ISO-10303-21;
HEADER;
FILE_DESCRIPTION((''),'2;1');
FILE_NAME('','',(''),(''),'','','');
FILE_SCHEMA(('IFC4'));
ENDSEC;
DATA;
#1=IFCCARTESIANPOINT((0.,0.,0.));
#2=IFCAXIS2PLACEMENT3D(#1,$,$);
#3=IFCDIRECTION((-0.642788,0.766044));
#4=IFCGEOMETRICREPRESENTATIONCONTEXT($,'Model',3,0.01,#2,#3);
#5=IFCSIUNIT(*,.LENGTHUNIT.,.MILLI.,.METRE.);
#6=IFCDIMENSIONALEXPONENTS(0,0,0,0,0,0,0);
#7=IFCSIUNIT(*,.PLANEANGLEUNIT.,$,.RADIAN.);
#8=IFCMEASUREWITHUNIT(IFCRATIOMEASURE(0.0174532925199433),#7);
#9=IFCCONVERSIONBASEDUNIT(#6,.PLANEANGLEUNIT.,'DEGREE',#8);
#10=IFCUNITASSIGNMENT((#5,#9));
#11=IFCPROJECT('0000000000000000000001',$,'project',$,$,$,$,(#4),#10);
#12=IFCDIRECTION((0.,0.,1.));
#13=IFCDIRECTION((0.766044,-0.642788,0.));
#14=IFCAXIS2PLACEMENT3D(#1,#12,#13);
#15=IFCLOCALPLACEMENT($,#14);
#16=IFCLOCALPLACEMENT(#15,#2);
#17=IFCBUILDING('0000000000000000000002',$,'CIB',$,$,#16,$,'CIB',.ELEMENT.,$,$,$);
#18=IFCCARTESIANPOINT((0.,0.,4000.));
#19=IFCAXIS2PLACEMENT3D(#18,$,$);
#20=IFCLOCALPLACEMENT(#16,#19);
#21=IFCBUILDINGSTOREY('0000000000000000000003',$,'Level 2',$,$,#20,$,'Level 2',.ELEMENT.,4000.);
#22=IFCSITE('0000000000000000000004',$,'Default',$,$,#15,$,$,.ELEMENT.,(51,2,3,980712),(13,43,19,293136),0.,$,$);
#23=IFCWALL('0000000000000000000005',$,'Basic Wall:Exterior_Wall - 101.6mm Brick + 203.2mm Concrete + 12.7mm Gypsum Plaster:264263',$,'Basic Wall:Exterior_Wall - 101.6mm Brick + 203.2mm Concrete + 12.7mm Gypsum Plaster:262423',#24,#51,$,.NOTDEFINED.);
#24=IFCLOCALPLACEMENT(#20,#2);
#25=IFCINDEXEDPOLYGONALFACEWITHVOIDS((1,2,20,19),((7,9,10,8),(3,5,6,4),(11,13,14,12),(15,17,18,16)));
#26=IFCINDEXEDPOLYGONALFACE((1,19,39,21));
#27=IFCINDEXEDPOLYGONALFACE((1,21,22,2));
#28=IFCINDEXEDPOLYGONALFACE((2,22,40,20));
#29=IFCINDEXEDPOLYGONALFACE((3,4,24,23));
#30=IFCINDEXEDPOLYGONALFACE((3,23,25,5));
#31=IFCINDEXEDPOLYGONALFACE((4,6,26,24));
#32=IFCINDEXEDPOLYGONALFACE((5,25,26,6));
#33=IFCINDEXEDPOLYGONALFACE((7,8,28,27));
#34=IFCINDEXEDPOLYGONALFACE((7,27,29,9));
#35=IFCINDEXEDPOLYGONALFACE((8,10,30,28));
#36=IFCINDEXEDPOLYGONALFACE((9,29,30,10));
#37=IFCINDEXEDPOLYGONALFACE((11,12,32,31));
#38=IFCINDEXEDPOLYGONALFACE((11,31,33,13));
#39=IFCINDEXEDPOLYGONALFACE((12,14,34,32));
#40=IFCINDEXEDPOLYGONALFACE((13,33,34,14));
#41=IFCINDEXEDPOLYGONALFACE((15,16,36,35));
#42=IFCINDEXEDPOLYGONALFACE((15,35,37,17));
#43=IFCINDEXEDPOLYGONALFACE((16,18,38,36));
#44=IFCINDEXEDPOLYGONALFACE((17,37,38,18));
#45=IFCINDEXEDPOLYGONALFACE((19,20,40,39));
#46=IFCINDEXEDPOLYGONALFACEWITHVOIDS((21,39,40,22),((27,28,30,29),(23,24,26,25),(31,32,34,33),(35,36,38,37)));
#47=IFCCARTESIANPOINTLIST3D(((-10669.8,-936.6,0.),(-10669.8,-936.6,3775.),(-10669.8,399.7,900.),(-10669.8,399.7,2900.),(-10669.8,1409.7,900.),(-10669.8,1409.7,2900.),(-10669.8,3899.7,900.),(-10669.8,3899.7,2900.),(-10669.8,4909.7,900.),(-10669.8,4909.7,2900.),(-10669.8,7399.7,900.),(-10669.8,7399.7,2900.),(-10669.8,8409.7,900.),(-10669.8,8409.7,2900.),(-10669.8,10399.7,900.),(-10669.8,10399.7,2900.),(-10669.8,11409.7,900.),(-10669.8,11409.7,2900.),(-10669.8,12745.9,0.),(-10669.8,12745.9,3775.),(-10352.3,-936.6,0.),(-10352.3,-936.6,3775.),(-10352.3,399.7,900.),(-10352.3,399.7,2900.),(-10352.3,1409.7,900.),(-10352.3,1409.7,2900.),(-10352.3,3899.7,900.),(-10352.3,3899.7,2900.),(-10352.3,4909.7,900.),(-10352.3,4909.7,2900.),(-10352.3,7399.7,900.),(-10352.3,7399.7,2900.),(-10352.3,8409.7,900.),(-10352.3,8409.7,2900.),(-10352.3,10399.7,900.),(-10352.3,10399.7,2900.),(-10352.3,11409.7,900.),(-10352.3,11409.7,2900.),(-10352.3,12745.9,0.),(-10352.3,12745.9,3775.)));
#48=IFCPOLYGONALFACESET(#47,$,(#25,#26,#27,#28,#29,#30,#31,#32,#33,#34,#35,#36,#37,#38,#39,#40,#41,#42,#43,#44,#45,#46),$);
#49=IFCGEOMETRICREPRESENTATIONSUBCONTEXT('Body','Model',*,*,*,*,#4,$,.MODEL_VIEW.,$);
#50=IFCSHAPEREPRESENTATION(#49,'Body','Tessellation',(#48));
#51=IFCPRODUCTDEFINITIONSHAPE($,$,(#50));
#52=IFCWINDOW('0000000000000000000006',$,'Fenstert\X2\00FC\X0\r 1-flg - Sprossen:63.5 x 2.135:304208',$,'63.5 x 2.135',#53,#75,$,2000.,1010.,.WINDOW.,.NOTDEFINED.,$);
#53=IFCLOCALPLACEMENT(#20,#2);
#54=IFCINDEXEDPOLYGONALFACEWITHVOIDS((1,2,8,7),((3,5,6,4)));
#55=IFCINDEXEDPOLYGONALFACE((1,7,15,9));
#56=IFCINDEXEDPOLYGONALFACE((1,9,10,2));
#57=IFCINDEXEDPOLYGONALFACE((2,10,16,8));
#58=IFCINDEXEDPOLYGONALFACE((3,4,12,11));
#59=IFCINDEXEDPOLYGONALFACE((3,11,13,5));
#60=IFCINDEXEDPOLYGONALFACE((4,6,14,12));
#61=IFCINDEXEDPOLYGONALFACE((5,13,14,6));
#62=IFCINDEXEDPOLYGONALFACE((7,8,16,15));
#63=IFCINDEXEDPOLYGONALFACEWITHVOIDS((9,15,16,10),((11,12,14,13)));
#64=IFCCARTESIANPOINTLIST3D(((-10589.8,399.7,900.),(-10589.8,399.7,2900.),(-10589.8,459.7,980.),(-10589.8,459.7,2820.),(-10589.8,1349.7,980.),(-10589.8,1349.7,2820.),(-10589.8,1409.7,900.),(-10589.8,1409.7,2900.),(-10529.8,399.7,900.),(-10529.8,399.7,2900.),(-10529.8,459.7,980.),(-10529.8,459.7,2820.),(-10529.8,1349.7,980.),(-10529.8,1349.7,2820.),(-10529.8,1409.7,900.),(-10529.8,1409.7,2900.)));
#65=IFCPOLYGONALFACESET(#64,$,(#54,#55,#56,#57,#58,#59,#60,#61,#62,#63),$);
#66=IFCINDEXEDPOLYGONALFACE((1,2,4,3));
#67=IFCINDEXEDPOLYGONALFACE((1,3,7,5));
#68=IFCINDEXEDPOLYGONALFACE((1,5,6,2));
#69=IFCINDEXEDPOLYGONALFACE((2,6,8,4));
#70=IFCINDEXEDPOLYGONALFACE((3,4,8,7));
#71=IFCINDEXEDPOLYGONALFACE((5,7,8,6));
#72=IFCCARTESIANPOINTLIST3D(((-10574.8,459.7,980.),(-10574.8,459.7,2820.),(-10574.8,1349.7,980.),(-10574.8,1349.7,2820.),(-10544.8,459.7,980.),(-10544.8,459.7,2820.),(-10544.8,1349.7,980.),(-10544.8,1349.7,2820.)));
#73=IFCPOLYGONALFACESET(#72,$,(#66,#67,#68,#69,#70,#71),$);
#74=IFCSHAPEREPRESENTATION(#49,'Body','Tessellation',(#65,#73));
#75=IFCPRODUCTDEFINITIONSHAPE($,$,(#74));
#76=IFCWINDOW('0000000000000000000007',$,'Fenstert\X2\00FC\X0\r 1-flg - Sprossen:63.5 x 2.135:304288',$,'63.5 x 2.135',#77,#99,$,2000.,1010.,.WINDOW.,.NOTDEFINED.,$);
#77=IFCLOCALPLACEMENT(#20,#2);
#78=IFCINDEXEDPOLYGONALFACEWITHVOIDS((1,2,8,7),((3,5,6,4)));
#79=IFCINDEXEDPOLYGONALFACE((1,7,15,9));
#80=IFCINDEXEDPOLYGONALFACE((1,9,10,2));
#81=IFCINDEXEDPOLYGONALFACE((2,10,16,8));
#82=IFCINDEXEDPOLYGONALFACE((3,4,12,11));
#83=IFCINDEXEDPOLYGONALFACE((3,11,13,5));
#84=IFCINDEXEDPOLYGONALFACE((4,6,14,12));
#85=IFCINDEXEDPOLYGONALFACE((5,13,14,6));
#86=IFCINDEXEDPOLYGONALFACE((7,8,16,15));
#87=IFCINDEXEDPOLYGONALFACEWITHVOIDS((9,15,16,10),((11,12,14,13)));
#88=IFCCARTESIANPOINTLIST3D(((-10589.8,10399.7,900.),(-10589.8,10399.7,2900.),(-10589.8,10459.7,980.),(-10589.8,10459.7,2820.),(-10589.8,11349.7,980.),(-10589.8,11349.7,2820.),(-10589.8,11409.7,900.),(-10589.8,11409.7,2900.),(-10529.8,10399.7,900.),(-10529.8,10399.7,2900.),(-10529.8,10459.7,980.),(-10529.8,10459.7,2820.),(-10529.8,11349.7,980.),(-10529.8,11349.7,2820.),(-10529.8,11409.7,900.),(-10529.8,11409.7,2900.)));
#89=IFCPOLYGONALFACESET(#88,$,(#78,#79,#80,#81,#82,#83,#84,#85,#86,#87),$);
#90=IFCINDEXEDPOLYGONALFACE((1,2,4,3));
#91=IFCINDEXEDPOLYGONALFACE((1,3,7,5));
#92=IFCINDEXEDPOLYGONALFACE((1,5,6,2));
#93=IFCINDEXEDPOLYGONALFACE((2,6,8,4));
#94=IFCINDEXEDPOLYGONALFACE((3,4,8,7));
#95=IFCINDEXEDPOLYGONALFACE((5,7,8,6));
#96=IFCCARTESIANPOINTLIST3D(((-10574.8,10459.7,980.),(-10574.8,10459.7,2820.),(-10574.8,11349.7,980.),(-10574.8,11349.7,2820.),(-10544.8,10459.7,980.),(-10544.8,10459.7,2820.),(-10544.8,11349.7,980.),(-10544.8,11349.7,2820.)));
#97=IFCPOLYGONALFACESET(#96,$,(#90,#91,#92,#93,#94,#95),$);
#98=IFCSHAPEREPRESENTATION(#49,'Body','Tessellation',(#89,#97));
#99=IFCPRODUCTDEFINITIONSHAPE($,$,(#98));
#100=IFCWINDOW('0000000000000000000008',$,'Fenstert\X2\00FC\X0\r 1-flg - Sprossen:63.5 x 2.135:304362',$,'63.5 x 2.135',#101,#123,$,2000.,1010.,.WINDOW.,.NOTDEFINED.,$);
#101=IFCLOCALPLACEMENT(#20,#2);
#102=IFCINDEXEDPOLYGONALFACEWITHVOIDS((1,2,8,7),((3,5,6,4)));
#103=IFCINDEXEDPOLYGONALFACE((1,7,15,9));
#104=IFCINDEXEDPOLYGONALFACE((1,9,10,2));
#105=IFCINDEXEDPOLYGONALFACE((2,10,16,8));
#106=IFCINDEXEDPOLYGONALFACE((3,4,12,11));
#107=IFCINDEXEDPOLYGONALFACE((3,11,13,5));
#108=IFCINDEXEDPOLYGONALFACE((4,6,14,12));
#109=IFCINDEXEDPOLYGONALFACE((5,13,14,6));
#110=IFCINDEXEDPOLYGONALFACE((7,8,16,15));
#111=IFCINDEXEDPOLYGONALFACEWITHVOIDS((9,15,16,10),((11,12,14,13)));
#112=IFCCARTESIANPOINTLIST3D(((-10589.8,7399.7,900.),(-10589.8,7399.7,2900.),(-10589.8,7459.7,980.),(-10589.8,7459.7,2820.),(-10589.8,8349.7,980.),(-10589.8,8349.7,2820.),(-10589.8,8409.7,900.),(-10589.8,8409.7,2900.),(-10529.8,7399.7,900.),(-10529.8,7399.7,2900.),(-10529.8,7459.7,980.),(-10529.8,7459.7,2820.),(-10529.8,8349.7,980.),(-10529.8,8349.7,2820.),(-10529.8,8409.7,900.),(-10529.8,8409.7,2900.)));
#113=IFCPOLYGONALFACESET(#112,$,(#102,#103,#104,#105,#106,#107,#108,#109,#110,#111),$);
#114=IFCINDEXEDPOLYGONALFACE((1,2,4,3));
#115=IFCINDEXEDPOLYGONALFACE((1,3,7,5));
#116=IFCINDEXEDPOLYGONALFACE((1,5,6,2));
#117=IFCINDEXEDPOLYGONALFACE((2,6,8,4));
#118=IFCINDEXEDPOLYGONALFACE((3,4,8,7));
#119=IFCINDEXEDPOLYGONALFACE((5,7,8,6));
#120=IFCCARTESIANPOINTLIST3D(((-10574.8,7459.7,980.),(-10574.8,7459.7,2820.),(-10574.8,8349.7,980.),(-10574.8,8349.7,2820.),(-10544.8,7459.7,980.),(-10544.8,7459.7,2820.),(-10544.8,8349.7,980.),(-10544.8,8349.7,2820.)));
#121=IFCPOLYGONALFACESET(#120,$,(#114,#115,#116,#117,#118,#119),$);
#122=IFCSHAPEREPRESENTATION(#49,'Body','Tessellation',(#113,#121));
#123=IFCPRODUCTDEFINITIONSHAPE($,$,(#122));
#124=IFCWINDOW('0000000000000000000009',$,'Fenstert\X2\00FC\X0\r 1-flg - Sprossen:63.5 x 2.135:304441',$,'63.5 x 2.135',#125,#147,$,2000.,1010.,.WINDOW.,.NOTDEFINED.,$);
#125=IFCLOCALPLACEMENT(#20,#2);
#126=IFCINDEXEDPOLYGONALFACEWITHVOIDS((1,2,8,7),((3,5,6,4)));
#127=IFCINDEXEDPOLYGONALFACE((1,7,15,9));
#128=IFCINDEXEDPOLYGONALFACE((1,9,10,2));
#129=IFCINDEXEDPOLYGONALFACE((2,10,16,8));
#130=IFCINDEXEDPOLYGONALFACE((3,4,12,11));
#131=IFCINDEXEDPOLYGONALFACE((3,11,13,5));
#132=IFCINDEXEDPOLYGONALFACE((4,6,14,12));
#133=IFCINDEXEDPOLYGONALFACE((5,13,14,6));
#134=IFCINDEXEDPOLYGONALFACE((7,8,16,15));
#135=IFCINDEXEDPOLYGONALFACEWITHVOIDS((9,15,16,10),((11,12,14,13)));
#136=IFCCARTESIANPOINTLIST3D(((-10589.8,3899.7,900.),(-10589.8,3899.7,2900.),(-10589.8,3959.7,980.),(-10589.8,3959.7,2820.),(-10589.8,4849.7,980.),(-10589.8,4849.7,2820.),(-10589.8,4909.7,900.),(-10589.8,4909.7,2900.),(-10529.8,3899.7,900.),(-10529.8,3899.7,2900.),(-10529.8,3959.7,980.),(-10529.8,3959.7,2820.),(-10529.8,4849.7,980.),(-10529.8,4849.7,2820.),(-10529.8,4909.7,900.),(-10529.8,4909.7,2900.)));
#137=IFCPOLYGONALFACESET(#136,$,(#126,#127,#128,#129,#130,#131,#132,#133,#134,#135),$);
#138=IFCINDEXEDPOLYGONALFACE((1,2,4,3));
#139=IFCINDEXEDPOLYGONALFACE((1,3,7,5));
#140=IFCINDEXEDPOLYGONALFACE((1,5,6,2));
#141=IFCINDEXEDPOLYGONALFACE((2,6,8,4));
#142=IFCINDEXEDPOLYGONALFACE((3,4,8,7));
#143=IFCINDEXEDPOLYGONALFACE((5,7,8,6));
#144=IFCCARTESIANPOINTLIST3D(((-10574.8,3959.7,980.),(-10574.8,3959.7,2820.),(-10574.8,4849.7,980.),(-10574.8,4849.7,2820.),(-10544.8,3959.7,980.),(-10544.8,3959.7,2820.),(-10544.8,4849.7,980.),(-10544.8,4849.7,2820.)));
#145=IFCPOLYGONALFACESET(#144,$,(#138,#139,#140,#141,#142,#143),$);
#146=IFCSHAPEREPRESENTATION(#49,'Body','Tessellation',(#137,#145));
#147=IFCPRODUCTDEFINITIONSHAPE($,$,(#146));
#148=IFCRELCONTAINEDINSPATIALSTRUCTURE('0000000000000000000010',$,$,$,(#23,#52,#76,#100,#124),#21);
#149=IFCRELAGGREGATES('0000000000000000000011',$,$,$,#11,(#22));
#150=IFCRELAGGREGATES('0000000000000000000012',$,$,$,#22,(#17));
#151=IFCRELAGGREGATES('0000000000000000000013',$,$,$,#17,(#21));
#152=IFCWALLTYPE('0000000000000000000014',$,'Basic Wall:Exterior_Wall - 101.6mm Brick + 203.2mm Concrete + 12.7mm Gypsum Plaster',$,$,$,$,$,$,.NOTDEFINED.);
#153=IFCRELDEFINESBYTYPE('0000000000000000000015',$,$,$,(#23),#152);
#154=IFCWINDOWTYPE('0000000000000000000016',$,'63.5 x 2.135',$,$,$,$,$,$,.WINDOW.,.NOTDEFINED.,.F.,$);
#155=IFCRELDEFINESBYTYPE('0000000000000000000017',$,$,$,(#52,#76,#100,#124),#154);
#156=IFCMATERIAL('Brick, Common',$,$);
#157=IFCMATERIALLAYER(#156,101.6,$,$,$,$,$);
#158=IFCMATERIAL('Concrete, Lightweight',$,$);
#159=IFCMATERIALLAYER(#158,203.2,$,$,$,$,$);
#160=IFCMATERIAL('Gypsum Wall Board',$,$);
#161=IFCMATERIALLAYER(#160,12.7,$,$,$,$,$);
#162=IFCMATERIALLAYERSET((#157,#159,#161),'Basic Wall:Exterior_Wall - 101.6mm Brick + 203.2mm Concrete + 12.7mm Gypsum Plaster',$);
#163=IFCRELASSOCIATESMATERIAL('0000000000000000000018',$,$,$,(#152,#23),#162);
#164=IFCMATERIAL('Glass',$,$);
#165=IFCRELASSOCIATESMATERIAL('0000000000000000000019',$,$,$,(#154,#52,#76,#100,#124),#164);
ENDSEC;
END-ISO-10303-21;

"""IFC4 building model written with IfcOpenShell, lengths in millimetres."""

from ifc_helpers import new_model, entity, si_unit, converted_unit, direction, frame, frame_2d, origin, origin_2d_with_axis, place, context, subcontext, project, spatial, polyline, rectangle, outline, extrude, clip, bounded_halfspace, source, transform, mapped, material, layer, layer_set, layer_usage, type_object, type_shapes, element, fill, save


model = new_model("IFC4")

# Units and contexts
model_context = context("Model", 3, precision=0.01, world=origin(), true_north=direction((-0.642788, 0.766044)))
body_context = subcontext(model_context, "Body", "Model", "MODEL_VIEW")
ifc_project = project(units=[si_unit("LENGTHUNIT", "METRE", prefix="MILLI"), converted_unit("PLANEANGLEUNIT", "DEGREE", entity("IfcRatioMeasure", 0.0174532925199433), si_unit("PLANEANGLEUNIT", "RADIAN"), dimensions=[0, 0, 0, 0, 0, 0, 0])], contexts=[model_context])

# Site, building, storey
site_placement = place(None, frame((0.0, 0.0, 0.0), z_axis=(0.0, 0.0, 1.0), x_axis=(0.766044, -0.642788, 0.0)))
site = spatial("IfcSite", under=ifc_project, at=site_placement, Name="Default", CompositionType="ELEMENT", RefLatitude=(51, 2, 3, 980712), RefLongitude=(13, 43, 19, 293136), RefElevation=0.0)
building_placement = place(site_placement, origin())
building = spatial("IfcBuilding", under=site, at=building_placement, Name="CIB", LongName="CIB", CompositionType="ELEMENT")
storey_placement = place(building_placement, frame((0.0, 0.0, 4000.0)))
storey = spatial("IfcBuildingStorey", under=building, at=storey_placement, Name="Level 2", LongName="Level 2", CompositionType="ELEMENT", Elevation=4000.0)

# Shared definitions
ifc_material_1 = material(Name="Brick, Common")
ifc_layer_1 = layer(ifc_material_1, 101.6)
ifc_material_2 = material(Name="Concrete, Lightweight")
ifc_layer_2 = layer(ifc_material_2, 203.2)
ifc_material_3 = material(Name="Gypsum Wall Board")
ifc_layer_3 = layer(ifc_material_3, 12.7)
ifc_layer_set_1 = layer_set([ifc_layer_1, ifc_layer_2, ifc_layer_3], Name="Basic Wall:Exterior_Wall - 101.6mm Brick + 203.2mm Concrete + 12.7mm Gypsum Plaster")
wall_type_1 = type_object("IfcWallType", Name="Basic Wall:Exterior_Wall - 101.6mm Brick + 203.2mm Concrete + 12.7mm Gypsum Plaster", PredefinedType="NOTDEFINED", material=ifc_layer_set_1)

# Wall, openings, windows
ifc_material_4 = material(Name="Glass")
window_type = type_object("IfcWindowType", Name="63.5 x 2.135", ParameterTakesPrecedence=False, PartitioningType="NOTDEFINED", PredefinedType="WINDOW", material=ifc_material_4)
shared_shape_1 = source(origin(), body_context, "Body", "SweptSolid", [
    extrude(outline(polyline([(-1000.0, -505.0), (1000.0, -505.0), (1000.0, 505.0), (-1000.0, 505.0), (-1000.0, -505.0)]), holes=[polyline([(-920.0, -445.0), (-920.0, 445.0), (920.0, 445.0), (920.0, -445.0), (-920.0, -445.0)])]), frame((505.0, 177.5, 1000.0), z_axis=(0.0, 1.0, 0.0), x_axis=(0.0, 0.0, -1.0)), (0.0, 0.0, 1.0), 60.0),
    extrude(rectangle(XDim=30.0, YDim=890.0, at=origin_2d_with_axis()), frame((505.0, 207.5, 80.0), z_axis=(0.0, 0.0, 1.0), x_axis=(0.0, 1.0, 0.0)), (0.0, 0.0, 1.0), 1840.0),
])
type_shapes(window_type, [shared_shape_1])
ifc_layer_usage_1 = layer_usage(ifc_layer_set_1, "AXIS2", "NEGATIVE", 158.8)
wall_1_placement = place(storey_placement, frame((-10511.0, -936.6, 0.0), z_axis=(0.0, 0.0, 1.0), x_axis=(0.0, 1.0, 0.0)))
wall_1 = element("IfcWall", 1, at=wall_1_placement, inside=storey, type_object=wall_type_1, material=ifc_layer_usage_1, Name="Basic Wall:Exterior_Wall - 101.6mm Brick + 203.2mm Concrete + 12.7mm Gypsum Plaster:264263", ObjectType="Basic Wall:Exterior_Wall - 101.6mm Brick + 203.2mm Concrete + 12.7mm Gypsum Plaster:262423", PredefinedType="NOTDEFINED", context=body_context, shape_type="Clipping", body=[
    clip(extrude(rectangle(XDim=13682.5, YDim=317.5, at=frame_2d((6841.2, 0.0), x_axis=(-1.0, 0.0))), origin(), (0.0, 0.0, 1.0), 3775.0), bounded_halfspace(frame((0.0, -158.7, 3775.0), z_axis=(0.0, 0.0, -1.0), x_axis=(1.0, 0.0, 0.0)), True, frame((0.0, -158.7, 3775.0)), polyline([(0.0, 0.0), (13682.5, 0.0), (13682.5, 317.5), (0.0, 317.5), (0.0, 0.0)]))),
])
opening_1_placement = place(wall_1_placement, frame((2346.2, 158.8, 900.0)))
opening_1 = element("IfcOpeningElement", 2, at=opening_1_placement, cuts=wall_1, ObjectType="Opening", PredefinedType="OPENING", context=body_context, shape_type="SweptSolid", body=[
    extrude(rectangle(XDim=2000.0, YDim=1010.0, at=frame_2d((1000.0, 505.0), x_axis=(1.0, 0.0))), frame((0.0, 0.0, 0.0), z_axis=(0.0, -1.0, 0.0), x_axis=(0.0, 0.0, 1.0)), (0.0, 0.0, 1.0), 317.5),
])
opening_2_placement = place(wall_1_placement, frame((12346.2, 158.8, 900.0)))
opening_2 = element("IfcOpeningElement", 3, at=opening_2_placement, cuts=wall_1, ObjectType="Opening", PredefinedType="OPENING", context=body_context, shape_type="SweptSolid", body=[
    extrude(rectangle(XDim=2000.0, YDim=1010.0, at=frame_2d((1000.0, 505.0), x_axis=(1.0, 0.0))), frame((0.0, 0.0, 0.0), z_axis=(0.0, -1.0, 0.0), x_axis=(0.0, 0.0, 1.0)), (0.0, 0.0, 1.0), 317.5),
])
opening_3_placement = place(wall_1_placement, frame((9346.2, 158.8, 900.0)))
opening_3 = element("IfcOpeningElement", 4, at=opening_3_placement, cuts=wall_1, ObjectType="Opening", PredefinedType="OPENING", context=body_context, shape_type="SweptSolid", body=[
    extrude(rectangle(XDim=2000.0, YDim=1010.0, at=frame_2d((1000.0, 505.0), x_axis=(1.0, 0.0))), frame((0.0, 0.0, 0.0), z_axis=(0.0, -1.0, 0.0), x_axis=(0.0, 0.0, 1.0)), (0.0, 0.0, 1.0), 317.5),
])
opening_4_placement = place(wall_1_placement, frame((5846.2, 158.8, 900.0)))
opening_4 = element("IfcOpeningElement", 5, at=opening_4_placement, cuts=wall_1, ObjectType="Opening", PredefinedType="OPENING", context=body_context, shape_type="SweptSolid", body=[
    extrude(rectangle(XDim=2000.0, YDim=1010.0, at=frame_2d((1000.0, 505.0), x_axis=(1.0, 0.0))), frame((0.0, 0.0, 0.0), z_axis=(0.0, -1.0, 0.0), x_axis=(0.0, 0.0, 1.0)), (0.0, 0.0, 1.0), 317.5),
])
window_1_placement = place(opening_1_placement, frame((-1010.0, -317.5, 0.0)))
window_1 = element("IfcWindow", 6, at=window_1_placement, inside=storey, type_object=window_type, material=ifc_material_4, Name="Fenstertür 1-flg - Sprossen:63.5 x 2.135:304208", ObjectType="63.5 x 2.135", OverallHeight=2000.0, OverallWidth=1010.0, PartitioningType="NOTDEFINED", PredefinedType="WINDOW", context=body_context, shape_type="MappedRepresentation", body=[
    mapped(shared_shape_1, transform((0.0, 0.0, 0.0), scale=1.0)),
])
fill(opening_1, window_1)
window_2_placement = place(opening_2_placement, frame((-1010.0, -317.5, 0.0)))
window_2 = element("IfcWindow", 7, at=window_2_placement, inside=storey, type_object=window_type, material=ifc_material_4, Name="Fenstertür 1-flg - Sprossen:63.5 x 2.135:304288", ObjectType="63.5 x 2.135", OverallHeight=2000.0, OverallWidth=1010.0, PartitioningType="NOTDEFINED", PredefinedType="WINDOW", context=body_context, shape_type="MappedRepresentation", body=[
    mapped(shared_shape_1, transform((0.0, 0.0, 0.0), scale=1.0)),
])
fill(opening_2, window_2)
window_3_placement = place(opening_3_placement, frame((-1010.0, -317.5, 0.0)))
window_3 = element("IfcWindow", 8, at=window_3_placement, inside=storey, type_object=window_type, material=ifc_material_4, Name="Fenstertür 1-flg - Sprossen:63.5 x 2.135:304362", ObjectType="63.5 x 2.135", OverallHeight=2000.0, OverallWidth=1010.0, PartitioningType="NOTDEFINED", PredefinedType="WINDOW", context=body_context, shape_type="MappedRepresentation", body=[
    mapped(shared_shape_1, transform((0.0, 0.0, 0.0), scale=1.0)),
])
fill(opening_3, window_3)
window_4_placement = place(opening_4_placement, frame((-1010.0, -317.5, 0.0)))
window_4 = element("IfcWindow", 9, at=window_4_placement, inside=storey, type_object=window_type, material=ifc_material_4, Name="Fenstertür 1-flg - Sprossen:63.5 x 2.135:304441", ObjectType="63.5 x 2.135", OverallHeight=2000.0, OverallWidth=1010.0, PartitioningType="NOTDEFINED", PredefinedType="WINDOW", context=body_context, shape_type="MappedRepresentation", body=[
    mapped(shared_shape_1, transform((0.0, 0.0, 0.0), scale=1.0)),
])
fill(opening_4, window_4)

save(model, "model.ifc")
